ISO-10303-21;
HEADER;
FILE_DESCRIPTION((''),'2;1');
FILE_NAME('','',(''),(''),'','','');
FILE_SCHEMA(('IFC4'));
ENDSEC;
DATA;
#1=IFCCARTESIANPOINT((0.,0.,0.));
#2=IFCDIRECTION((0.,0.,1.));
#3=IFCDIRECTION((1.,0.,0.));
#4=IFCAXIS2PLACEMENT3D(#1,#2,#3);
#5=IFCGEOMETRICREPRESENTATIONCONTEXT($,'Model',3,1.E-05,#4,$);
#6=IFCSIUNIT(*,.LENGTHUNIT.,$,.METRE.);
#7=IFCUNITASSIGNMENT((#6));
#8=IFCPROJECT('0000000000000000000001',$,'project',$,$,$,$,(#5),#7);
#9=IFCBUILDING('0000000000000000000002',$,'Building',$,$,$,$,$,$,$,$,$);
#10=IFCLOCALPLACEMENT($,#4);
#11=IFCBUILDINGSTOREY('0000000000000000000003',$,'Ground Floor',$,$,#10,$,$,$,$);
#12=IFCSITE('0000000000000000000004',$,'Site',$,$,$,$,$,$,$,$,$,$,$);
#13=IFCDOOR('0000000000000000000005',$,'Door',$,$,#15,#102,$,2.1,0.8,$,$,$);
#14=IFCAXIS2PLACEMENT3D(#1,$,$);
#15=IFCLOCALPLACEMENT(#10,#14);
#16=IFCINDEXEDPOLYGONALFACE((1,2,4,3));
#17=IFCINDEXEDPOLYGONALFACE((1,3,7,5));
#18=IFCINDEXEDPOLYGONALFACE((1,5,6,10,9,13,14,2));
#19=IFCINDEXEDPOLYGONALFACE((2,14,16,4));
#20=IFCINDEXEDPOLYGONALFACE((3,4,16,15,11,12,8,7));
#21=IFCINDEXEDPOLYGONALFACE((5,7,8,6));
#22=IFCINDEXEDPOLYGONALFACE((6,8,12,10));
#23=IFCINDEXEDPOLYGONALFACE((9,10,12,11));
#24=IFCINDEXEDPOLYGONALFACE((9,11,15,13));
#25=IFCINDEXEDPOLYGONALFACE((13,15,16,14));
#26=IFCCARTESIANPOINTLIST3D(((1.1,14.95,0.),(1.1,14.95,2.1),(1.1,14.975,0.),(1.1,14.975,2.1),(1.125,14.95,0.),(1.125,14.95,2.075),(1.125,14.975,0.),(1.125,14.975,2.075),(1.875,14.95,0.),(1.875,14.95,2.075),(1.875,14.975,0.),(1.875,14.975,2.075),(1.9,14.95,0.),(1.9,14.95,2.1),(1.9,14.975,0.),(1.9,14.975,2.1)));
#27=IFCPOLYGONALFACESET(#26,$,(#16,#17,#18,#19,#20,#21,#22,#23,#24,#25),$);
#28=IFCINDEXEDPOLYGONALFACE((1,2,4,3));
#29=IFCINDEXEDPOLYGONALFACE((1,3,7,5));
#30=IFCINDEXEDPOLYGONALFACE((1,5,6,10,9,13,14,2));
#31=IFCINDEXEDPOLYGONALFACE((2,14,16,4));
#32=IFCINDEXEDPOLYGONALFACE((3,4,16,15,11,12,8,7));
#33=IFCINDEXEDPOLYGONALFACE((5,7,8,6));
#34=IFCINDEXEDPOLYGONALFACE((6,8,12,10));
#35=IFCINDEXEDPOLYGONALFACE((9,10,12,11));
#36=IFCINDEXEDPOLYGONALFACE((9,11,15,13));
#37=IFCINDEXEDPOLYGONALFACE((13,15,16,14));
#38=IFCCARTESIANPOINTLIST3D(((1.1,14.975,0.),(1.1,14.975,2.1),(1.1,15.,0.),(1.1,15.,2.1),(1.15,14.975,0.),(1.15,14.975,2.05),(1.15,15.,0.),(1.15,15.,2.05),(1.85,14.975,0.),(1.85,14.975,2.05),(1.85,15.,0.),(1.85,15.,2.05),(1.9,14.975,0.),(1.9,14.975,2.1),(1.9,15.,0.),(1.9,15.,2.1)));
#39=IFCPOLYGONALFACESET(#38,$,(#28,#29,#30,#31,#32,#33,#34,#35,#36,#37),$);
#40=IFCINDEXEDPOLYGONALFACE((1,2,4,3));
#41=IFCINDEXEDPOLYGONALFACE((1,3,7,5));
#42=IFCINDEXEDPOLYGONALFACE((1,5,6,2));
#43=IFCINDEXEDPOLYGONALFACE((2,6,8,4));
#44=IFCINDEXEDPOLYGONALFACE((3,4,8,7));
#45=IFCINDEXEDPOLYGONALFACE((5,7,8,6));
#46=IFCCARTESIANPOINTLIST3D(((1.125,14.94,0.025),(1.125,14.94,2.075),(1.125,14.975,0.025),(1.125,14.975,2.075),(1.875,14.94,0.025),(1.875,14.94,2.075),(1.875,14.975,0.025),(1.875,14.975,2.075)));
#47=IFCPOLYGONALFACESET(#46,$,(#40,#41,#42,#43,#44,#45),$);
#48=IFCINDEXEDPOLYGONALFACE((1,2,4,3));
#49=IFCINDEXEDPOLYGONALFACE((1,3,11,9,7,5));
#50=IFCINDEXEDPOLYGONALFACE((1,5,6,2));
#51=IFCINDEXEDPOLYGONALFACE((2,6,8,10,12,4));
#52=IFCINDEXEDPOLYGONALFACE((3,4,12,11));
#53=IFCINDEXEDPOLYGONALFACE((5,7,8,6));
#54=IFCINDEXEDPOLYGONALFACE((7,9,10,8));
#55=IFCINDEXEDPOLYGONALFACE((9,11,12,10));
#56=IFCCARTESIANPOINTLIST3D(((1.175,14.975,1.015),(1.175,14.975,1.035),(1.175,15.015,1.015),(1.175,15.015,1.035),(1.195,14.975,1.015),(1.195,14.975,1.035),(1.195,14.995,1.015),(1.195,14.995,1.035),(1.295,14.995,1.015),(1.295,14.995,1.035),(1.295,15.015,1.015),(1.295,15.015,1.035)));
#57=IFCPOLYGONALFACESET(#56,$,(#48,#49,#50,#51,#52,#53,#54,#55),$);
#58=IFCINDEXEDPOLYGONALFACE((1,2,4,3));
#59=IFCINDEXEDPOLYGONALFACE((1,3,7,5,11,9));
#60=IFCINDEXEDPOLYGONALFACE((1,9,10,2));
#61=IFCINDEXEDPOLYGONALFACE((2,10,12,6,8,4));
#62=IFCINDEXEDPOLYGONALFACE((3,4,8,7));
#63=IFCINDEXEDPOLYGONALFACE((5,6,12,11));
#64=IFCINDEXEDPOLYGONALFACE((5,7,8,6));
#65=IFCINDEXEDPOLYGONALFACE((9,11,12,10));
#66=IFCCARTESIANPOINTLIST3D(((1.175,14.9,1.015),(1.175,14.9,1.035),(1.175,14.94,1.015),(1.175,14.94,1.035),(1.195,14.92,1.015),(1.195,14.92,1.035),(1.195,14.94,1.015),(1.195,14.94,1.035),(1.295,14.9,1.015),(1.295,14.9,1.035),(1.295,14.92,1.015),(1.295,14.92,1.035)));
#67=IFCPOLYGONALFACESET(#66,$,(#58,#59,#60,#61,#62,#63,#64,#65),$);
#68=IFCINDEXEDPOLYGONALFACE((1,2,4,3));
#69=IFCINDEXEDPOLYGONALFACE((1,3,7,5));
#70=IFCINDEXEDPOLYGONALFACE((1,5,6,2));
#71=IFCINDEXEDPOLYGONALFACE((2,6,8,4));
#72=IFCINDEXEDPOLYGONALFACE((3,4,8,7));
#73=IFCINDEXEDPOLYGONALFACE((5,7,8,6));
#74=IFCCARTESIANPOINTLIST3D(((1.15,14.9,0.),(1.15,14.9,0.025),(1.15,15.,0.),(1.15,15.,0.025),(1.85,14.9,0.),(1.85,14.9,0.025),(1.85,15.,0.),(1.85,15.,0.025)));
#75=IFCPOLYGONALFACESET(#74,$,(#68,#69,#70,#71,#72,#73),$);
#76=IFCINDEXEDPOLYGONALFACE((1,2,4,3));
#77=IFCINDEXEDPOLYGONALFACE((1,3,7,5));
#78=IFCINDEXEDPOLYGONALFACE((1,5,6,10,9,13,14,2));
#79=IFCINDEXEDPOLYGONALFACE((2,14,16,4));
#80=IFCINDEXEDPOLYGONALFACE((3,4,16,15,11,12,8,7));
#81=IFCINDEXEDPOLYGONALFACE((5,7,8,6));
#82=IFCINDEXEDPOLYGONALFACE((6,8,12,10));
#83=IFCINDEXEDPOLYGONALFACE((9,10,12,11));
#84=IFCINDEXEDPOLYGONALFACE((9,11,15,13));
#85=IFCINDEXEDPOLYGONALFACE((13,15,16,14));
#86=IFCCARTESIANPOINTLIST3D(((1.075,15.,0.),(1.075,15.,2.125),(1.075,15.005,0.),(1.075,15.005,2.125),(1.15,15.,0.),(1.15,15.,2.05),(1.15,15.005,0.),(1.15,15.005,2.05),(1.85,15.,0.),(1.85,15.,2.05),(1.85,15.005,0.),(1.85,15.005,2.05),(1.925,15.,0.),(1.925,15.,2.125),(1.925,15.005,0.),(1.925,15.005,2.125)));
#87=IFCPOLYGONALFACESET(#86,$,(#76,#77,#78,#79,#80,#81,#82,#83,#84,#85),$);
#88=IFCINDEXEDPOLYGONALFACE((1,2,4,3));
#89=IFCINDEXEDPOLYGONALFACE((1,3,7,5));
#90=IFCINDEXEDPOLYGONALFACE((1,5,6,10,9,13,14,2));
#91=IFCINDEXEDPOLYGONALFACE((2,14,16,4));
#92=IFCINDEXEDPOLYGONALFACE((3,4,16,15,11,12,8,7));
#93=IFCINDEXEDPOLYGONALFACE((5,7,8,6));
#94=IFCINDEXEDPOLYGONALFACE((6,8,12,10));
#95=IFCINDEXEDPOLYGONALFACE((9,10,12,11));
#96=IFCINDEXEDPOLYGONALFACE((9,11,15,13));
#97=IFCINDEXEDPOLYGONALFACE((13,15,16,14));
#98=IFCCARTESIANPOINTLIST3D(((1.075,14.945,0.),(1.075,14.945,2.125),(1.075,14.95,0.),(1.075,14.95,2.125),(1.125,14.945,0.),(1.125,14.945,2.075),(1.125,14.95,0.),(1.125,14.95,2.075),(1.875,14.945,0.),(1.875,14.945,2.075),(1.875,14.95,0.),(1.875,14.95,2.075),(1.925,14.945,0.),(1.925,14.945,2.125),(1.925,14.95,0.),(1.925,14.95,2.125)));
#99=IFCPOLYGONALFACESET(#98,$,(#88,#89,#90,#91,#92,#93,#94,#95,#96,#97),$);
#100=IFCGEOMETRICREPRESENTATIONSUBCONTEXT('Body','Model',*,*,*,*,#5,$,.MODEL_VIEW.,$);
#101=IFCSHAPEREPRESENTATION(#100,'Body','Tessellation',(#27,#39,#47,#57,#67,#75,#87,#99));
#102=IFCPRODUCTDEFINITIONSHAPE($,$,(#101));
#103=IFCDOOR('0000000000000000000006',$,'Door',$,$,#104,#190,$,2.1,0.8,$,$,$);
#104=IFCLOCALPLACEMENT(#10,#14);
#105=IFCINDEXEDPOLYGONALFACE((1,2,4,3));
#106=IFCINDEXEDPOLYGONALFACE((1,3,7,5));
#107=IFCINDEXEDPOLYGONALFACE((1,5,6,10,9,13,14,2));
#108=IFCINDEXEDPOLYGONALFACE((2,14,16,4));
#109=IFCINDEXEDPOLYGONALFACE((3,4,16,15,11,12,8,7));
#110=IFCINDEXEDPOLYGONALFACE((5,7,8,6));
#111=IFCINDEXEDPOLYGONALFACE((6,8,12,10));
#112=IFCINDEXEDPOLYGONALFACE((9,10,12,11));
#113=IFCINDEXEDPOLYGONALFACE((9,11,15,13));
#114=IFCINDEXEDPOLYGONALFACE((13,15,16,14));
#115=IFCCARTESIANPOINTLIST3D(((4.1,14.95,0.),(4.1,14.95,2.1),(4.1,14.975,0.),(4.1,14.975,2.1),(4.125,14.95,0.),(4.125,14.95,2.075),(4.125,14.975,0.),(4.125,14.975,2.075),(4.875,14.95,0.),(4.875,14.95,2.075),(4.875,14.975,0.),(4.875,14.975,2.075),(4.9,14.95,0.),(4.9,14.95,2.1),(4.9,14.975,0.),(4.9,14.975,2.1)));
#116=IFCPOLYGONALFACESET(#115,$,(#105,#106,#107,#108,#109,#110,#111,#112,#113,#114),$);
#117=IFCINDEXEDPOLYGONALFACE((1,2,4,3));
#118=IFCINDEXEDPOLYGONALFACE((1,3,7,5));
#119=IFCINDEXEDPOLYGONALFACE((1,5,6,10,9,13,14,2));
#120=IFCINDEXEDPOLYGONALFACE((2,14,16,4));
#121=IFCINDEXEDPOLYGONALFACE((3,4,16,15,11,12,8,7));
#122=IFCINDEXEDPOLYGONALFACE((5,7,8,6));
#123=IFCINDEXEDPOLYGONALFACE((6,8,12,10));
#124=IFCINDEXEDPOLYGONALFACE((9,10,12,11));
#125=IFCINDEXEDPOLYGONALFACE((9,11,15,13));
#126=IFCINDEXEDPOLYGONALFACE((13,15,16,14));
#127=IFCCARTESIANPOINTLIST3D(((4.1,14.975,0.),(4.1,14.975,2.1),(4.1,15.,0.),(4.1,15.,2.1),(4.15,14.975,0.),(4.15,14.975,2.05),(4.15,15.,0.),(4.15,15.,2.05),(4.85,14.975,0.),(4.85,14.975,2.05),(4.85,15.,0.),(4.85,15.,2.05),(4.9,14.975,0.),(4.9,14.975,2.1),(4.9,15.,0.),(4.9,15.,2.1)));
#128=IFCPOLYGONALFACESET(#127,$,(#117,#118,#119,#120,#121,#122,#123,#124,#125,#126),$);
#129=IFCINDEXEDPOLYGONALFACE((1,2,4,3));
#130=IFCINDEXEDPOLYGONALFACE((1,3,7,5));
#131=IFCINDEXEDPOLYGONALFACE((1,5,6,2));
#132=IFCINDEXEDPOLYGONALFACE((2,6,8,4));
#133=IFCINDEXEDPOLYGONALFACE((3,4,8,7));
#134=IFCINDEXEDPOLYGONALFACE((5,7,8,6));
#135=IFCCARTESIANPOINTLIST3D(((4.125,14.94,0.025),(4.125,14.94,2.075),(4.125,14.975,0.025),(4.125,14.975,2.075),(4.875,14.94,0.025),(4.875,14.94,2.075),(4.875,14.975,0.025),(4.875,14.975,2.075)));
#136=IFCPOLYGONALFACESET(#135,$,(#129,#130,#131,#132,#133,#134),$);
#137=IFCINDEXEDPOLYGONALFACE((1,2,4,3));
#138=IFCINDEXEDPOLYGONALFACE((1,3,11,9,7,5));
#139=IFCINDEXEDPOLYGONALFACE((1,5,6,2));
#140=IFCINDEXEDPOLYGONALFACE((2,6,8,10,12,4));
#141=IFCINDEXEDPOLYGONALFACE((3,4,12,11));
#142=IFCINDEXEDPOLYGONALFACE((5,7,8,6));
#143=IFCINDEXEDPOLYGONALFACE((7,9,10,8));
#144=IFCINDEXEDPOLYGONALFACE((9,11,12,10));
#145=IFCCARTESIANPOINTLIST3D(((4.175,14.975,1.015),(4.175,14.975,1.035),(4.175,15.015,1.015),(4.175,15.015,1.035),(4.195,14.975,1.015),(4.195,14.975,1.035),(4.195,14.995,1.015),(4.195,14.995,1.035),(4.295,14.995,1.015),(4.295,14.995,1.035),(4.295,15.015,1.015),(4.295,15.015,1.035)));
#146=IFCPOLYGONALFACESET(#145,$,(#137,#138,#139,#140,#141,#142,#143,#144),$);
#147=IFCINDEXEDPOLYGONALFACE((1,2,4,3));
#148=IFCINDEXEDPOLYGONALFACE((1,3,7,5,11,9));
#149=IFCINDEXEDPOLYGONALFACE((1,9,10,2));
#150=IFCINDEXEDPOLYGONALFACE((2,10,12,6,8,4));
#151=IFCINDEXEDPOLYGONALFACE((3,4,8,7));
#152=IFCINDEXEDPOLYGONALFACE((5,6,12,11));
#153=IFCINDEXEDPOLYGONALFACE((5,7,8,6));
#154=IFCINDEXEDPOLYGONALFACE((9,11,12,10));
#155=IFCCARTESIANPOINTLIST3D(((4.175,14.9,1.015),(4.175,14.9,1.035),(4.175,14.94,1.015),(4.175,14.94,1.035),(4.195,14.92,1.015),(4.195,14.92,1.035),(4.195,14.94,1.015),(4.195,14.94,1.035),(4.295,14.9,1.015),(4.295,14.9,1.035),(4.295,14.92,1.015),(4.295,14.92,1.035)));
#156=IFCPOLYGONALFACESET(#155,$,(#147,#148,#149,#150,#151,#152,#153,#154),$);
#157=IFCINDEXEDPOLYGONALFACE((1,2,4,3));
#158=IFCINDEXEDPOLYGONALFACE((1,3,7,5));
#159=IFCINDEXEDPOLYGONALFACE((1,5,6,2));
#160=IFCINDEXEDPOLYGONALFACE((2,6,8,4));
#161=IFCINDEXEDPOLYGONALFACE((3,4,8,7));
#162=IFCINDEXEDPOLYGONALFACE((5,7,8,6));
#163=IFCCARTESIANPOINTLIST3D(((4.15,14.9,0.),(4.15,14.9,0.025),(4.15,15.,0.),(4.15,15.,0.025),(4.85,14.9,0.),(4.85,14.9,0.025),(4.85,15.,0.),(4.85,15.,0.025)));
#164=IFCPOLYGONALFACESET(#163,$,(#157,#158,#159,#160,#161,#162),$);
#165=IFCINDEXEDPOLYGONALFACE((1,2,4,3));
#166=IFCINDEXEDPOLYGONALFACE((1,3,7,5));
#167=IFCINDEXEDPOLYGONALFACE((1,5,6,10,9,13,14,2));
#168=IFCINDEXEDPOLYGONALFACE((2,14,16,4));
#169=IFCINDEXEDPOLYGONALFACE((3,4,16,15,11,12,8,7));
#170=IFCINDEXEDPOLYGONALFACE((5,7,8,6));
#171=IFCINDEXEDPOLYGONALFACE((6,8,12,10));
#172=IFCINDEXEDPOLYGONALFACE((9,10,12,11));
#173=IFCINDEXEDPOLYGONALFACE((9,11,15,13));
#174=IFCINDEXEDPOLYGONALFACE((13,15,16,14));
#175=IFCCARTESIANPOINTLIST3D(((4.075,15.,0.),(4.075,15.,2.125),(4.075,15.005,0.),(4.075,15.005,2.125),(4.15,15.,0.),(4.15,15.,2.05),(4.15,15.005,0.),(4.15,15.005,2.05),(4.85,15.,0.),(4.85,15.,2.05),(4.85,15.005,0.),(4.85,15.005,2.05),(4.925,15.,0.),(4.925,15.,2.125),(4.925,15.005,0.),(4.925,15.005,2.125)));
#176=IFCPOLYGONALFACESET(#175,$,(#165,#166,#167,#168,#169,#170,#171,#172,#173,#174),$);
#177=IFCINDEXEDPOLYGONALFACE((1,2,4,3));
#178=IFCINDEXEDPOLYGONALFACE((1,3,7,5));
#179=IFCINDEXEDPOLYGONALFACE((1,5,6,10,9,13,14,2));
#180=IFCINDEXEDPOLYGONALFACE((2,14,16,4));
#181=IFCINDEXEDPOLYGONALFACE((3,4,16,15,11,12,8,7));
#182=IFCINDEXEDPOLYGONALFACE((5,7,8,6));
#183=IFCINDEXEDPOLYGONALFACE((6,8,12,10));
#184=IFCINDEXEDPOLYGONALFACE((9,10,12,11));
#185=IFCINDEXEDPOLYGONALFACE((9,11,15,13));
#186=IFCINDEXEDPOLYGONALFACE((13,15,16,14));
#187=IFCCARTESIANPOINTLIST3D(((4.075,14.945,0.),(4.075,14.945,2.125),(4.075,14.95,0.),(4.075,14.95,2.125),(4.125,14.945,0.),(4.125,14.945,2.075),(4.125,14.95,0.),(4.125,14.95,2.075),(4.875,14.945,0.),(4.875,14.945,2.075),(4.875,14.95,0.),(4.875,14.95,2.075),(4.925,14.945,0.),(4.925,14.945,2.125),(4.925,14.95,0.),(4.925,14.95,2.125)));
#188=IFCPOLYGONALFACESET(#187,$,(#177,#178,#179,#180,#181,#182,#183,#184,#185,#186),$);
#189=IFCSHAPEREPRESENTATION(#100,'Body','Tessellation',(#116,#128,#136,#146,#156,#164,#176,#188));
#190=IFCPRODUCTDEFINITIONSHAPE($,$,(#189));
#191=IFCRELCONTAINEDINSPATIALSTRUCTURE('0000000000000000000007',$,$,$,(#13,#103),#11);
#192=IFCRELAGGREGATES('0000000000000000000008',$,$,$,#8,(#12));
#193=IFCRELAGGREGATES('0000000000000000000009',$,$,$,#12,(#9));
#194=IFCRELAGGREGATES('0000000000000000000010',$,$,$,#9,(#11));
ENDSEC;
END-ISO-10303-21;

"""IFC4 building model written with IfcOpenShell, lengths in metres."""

from ifc_helpers import new_model, si_unit, frame, origin_with_axes, place, context, subcontext, project, spatial, line, indexed_curve, outline, extrude, element, save


model = new_model("IFC4")

# Units and contexts
model_context = context("Model", 3, precision=1e-05, world=origin_with_axes())
body_context = subcontext(model_context, "Body", "Model", "MODEL_VIEW")
ifc_project = project(units=[si_unit("LENGTHUNIT", "METRE")], contexts=[model_context])

# Site, building, storey
site = spatial("IfcSite", under=ifc_project, Name="Site")
building = spatial("IfcBuilding", under=site, Name="Building")
storey_placement = place(None, origin_with_axes())
storey = spatial("IfcBuildingStorey", under=building, at=storey_placement, Name="Ground Floor")

# Doors
door_1_placement = place(storey_placement, frame((1.9, 15.0, 0.0), z_axis=(0.0, 0.0, 1.0), x_axis=(-1.0, 0.0, 0.0)))
element("IfcDoor", 1, at=door_1_placement, inside=storey, Name="Door", OverallHeight=2.1, OverallWidth=0.8, context=body_context, shape_type="SweptSolid", body=[
    extrude(outline(indexed_curve([(0.0, 0.0), (0.0, 2.1), (0.8, 2.1), (0.8, 0.0), (0.775, 0.0), (0.775, 2.075), (0.025, 2.075), (0.025, 0.0)], segments=[line(1, 2, 3, 4, 5, 6, 7, 8, 1)])), frame((0.0, 0.025, 0.0), z_axis=(0.0, -1.0, 0.0), x_axis=(1.0, 0.0, 0.0)), (0.0, 0.0, -1.0), 0.025),
    extrude(outline(indexed_curve([(0.0, 0.0), (0.0, 2.1), (0.8, 2.1), (0.8, 0.0), (0.75, 0.0), (0.75, 2.05), (0.05, 2.05), (0.05, 0.0)], segments=[line(1, 2, 3, 4, 5, 6, 7, 8, 1)])), frame((0.0, 0.0, 0.0), z_axis=(0.0, -1.0, 0.0), x_axis=(1.0, 0.0, 0.0)), (0.0, 0.0, -1.0), 0.025),
    extrude(outline(indexed_curve([(0.0, 0.0), (0.75, 0.0), (0.75, 0.035), (0.0, 0.035)], segments=[line(1, 2, 3, 4, 1)])), frame((0.025, 0.025, 0.025), z_axis=(0.0, 0.0, 1.0), x_axis=(1.0, 0.0, 0.0)), (0.0, 0.0, 1.0), 2.05),
    extrude(outline(indexed_curve([(0.0, 0.0), (0.0, -0.04), (-0.12, -0.04), (-0.12, -0.02), (-0.02, -0.02), (-0.02, 0.0)], segments=[line(1, 2, 3, 4, 5, 6, 1)])), frame((0.725, 0.025, 1.015), z_axis=(0.0, 0.0, 1.0), x_axis=(1.0, 0.0, 0.0)), (0.0, 0.0, 1.0), 0.02),
    extrude(outline(indexed_curve([(0.0, 0.0), (0.0, 0.04), (-0.12, 0.04), (-0.12, 0.02), (-0.02, 0.02), (-0.02, 0.0)], segments=[line(1, 2, 3, 4, 5, 6, 1)])), frame((0.725, 0.06, 1.015), z_axis=(0.0, 0.0, 1.0), x_axis=(1.0, 0.0, 0.0)), (0.0, 0.0, 1.0), 0.02),
    extrude(outline(indexed_curve([(0.0, 0.0), (0.7, 0.0), (0.7, 0.1), (0.0, 0.1)], segments=[line(1, 2, 3, 4, 1)])), frame((0.05, 0.0, 0.0), z_axis=(0.0, 0.0, 1.0), x_axis=(1.0, 0.0, 0.0)), (0.0, 0.0, 1.0), 0.025),
    extrude(outline(indexed_curve([(0.0, 0.0), (0.0, 2.125), (0.85, 2.125), (0.85, 0.0), (0.775, 0.0), (0.775, 2.05), (0.075, 2.05), (0.075, 0.0)], segments=[line(1, 2, 3, 4, 5, 6, 7, 8, 1)])), frame((-0.025, -0.005, 0.0), z_axis=(0.0, -1.0, 0.0), x_axis=(1.0, 0.0, 0.0)), (0.0, 0.0, -1.0), 0.005),
    extrude(outline(indexed_curve([(0.0, 0.0), (0.0, 2.125), (0.85, 2.125), (0.85, 0.0), (0.8, 0.0), (0.8, 2.075), (0.05, 2.075), (0.05, 0.0)], segments=[line(1, 2, 3, 4, 5, 6, 7, 8, 1)])), frame((-0.025, 0.05, 0.0), z_axis=(0.0, -1.0, 0.0), x_axis=(1.0, 0.0, 0.0)), (0.0, 0.0, -1.0), 0.005),
])
door_2_placement = place(storey_placement, frame((4.9, 15.0, 0.0), z_axis=(0.0, 0.0, 1.0), x_axis=(-1.0, 0.0, 0.0)))
element("IfcDoor", 2, at=door_2_placement, inside=storey, Name="Door", OverallHeight=2.1, OverallWidth=0.8, context=body_context, shape_type="SweptSolid", body=[
    extrude(outline(indexed_curve([(0.0, 0.0), (0.0, 2.1), (0.8, 2.1), (0.8, 0.0), (0.775, 0.0), (0.775, 2.075), (0.025, 2.075), (0.025, 0.0)], segments=[line(1, 2, 3, 4, 5, 6, 7, 8, 1)])), frame((0.0, 0.025, 0.0), z_axis=(0.0, -1.0, 0.0), x_axis=(1.0, 0.0, 0.0)), (0.0, 0.0, -1.0), 0.025),
    extrude(outline(indexed_curve([(0.0, 0.0), (0.0, 2.1), (0.8, 2.1), (0.8, 0.0), (0.75, 0.0), (0.75, 2.05), (0.05, 2.05), (0.05, 0.0)], segments=[line(1, 2, 3, 4, 5, 6, 7, 8, 1)])), frame((0.0, 0.0, 0.0), z_axis=(0.0, -1.0, 0.0), x_axis=(1.0, 0.0, 0.0)), (0.0, 0.0, -1.0), 0.025),
    extrude(outline(indexed_curve([(0.0, 0.0), (0.75, 0.0), (0.75, 0.035), (0.0, 0.035)], segments=[line(1, 2, 3, 4, 1)])), frame((0.025, 0.025, 0.025), z_axis=(0.0, 0.0, 1.0), x_axis=(1.0, 0.0, 0.0)), (0.0, 0.0, 1.0), 2.05),
    extrude(outline(indexed_curve([(0.0, 0.0), (0.0, -0.04), (-0.12, -0.04), (-0.12, -0.02), (-0.02, -0.02), (-0.02, 0.0)], segments=[line(1, 2, 3, 4, 5, 6, 1)])), frame((0.725, 0.025, 1.015), z_axis=(0.0, 0.0, 1.0), x_axis=(1.0, 0.0, 0.0)), (0.0, 0.0, 1.0), 0.02),
    extrude(outline(indexed_curve([(0.0, 0.0), (0.0, 0.04), (-0.12, 0.04), (-0.12, 0.02), (-0.02, 0.02), (-0.02, 0.0)], segments=[line(1, 2, 3, 4, 5, 6, 1)])), frame((0.725, 0.06, 1.015), z_axis=(0.0, 0.0, 1.0), x_axis=(1.0, 0.0, 0.0)), (0.0, 0.0, 1.0), 0.02),
    extrude(outline(indexed_curve([(0.0, 0.0), (0.7, 0.0), (0.7, 0.1), (0.0, 0.1)], segments=[line(1, 2, 3, 4, 1)])), frame((0.05, 0.0, 0.0), z_axis=(0.0, 0.0, 1.0), x_axis=(1.0, 0.0, 0.0)), (0.0, 0.0, 1.0), 0.025),
    extrude(outline(indexed_curve([(0.0, 0.0), (0.0, 2.125), (0.85, 2.125), (0.85, 0.0), (0.775, 0.0), (0.775, 2.05), (0.075, 2.05), (0.075, 0.0)], segments=[line(1, 2, 3, 4, 5, 6, 7, 8, 1)])), frame((-0.025, -0.005, 0.0), z_axis=(0.0, -1.0, 0.0), x_axis=(1.0, 0.0, 0.0)), (0.0, 0.0, -1.0), 0.005),
    extrude(outline(indexed_curve([(0.0, 0.0), (0.0, 2.125), (0.85, 2.125), (0.85, 0.0), (0.8, 0.0), (0.8, 2.075), (0.05, 2.075), (0.05, 0.0)], segments=[line(1, 2, 3, 4, 5, 6, 7, 8, 1)])), frame((-0.025, 0.05, 0.0), z_axis=(0.0, -1.0, 0.0), x_axis=(1.0, 0.0, 0.0)), (0.0, 0.0, -1.0), 0.005),
])

save(model, "model.ifc")
